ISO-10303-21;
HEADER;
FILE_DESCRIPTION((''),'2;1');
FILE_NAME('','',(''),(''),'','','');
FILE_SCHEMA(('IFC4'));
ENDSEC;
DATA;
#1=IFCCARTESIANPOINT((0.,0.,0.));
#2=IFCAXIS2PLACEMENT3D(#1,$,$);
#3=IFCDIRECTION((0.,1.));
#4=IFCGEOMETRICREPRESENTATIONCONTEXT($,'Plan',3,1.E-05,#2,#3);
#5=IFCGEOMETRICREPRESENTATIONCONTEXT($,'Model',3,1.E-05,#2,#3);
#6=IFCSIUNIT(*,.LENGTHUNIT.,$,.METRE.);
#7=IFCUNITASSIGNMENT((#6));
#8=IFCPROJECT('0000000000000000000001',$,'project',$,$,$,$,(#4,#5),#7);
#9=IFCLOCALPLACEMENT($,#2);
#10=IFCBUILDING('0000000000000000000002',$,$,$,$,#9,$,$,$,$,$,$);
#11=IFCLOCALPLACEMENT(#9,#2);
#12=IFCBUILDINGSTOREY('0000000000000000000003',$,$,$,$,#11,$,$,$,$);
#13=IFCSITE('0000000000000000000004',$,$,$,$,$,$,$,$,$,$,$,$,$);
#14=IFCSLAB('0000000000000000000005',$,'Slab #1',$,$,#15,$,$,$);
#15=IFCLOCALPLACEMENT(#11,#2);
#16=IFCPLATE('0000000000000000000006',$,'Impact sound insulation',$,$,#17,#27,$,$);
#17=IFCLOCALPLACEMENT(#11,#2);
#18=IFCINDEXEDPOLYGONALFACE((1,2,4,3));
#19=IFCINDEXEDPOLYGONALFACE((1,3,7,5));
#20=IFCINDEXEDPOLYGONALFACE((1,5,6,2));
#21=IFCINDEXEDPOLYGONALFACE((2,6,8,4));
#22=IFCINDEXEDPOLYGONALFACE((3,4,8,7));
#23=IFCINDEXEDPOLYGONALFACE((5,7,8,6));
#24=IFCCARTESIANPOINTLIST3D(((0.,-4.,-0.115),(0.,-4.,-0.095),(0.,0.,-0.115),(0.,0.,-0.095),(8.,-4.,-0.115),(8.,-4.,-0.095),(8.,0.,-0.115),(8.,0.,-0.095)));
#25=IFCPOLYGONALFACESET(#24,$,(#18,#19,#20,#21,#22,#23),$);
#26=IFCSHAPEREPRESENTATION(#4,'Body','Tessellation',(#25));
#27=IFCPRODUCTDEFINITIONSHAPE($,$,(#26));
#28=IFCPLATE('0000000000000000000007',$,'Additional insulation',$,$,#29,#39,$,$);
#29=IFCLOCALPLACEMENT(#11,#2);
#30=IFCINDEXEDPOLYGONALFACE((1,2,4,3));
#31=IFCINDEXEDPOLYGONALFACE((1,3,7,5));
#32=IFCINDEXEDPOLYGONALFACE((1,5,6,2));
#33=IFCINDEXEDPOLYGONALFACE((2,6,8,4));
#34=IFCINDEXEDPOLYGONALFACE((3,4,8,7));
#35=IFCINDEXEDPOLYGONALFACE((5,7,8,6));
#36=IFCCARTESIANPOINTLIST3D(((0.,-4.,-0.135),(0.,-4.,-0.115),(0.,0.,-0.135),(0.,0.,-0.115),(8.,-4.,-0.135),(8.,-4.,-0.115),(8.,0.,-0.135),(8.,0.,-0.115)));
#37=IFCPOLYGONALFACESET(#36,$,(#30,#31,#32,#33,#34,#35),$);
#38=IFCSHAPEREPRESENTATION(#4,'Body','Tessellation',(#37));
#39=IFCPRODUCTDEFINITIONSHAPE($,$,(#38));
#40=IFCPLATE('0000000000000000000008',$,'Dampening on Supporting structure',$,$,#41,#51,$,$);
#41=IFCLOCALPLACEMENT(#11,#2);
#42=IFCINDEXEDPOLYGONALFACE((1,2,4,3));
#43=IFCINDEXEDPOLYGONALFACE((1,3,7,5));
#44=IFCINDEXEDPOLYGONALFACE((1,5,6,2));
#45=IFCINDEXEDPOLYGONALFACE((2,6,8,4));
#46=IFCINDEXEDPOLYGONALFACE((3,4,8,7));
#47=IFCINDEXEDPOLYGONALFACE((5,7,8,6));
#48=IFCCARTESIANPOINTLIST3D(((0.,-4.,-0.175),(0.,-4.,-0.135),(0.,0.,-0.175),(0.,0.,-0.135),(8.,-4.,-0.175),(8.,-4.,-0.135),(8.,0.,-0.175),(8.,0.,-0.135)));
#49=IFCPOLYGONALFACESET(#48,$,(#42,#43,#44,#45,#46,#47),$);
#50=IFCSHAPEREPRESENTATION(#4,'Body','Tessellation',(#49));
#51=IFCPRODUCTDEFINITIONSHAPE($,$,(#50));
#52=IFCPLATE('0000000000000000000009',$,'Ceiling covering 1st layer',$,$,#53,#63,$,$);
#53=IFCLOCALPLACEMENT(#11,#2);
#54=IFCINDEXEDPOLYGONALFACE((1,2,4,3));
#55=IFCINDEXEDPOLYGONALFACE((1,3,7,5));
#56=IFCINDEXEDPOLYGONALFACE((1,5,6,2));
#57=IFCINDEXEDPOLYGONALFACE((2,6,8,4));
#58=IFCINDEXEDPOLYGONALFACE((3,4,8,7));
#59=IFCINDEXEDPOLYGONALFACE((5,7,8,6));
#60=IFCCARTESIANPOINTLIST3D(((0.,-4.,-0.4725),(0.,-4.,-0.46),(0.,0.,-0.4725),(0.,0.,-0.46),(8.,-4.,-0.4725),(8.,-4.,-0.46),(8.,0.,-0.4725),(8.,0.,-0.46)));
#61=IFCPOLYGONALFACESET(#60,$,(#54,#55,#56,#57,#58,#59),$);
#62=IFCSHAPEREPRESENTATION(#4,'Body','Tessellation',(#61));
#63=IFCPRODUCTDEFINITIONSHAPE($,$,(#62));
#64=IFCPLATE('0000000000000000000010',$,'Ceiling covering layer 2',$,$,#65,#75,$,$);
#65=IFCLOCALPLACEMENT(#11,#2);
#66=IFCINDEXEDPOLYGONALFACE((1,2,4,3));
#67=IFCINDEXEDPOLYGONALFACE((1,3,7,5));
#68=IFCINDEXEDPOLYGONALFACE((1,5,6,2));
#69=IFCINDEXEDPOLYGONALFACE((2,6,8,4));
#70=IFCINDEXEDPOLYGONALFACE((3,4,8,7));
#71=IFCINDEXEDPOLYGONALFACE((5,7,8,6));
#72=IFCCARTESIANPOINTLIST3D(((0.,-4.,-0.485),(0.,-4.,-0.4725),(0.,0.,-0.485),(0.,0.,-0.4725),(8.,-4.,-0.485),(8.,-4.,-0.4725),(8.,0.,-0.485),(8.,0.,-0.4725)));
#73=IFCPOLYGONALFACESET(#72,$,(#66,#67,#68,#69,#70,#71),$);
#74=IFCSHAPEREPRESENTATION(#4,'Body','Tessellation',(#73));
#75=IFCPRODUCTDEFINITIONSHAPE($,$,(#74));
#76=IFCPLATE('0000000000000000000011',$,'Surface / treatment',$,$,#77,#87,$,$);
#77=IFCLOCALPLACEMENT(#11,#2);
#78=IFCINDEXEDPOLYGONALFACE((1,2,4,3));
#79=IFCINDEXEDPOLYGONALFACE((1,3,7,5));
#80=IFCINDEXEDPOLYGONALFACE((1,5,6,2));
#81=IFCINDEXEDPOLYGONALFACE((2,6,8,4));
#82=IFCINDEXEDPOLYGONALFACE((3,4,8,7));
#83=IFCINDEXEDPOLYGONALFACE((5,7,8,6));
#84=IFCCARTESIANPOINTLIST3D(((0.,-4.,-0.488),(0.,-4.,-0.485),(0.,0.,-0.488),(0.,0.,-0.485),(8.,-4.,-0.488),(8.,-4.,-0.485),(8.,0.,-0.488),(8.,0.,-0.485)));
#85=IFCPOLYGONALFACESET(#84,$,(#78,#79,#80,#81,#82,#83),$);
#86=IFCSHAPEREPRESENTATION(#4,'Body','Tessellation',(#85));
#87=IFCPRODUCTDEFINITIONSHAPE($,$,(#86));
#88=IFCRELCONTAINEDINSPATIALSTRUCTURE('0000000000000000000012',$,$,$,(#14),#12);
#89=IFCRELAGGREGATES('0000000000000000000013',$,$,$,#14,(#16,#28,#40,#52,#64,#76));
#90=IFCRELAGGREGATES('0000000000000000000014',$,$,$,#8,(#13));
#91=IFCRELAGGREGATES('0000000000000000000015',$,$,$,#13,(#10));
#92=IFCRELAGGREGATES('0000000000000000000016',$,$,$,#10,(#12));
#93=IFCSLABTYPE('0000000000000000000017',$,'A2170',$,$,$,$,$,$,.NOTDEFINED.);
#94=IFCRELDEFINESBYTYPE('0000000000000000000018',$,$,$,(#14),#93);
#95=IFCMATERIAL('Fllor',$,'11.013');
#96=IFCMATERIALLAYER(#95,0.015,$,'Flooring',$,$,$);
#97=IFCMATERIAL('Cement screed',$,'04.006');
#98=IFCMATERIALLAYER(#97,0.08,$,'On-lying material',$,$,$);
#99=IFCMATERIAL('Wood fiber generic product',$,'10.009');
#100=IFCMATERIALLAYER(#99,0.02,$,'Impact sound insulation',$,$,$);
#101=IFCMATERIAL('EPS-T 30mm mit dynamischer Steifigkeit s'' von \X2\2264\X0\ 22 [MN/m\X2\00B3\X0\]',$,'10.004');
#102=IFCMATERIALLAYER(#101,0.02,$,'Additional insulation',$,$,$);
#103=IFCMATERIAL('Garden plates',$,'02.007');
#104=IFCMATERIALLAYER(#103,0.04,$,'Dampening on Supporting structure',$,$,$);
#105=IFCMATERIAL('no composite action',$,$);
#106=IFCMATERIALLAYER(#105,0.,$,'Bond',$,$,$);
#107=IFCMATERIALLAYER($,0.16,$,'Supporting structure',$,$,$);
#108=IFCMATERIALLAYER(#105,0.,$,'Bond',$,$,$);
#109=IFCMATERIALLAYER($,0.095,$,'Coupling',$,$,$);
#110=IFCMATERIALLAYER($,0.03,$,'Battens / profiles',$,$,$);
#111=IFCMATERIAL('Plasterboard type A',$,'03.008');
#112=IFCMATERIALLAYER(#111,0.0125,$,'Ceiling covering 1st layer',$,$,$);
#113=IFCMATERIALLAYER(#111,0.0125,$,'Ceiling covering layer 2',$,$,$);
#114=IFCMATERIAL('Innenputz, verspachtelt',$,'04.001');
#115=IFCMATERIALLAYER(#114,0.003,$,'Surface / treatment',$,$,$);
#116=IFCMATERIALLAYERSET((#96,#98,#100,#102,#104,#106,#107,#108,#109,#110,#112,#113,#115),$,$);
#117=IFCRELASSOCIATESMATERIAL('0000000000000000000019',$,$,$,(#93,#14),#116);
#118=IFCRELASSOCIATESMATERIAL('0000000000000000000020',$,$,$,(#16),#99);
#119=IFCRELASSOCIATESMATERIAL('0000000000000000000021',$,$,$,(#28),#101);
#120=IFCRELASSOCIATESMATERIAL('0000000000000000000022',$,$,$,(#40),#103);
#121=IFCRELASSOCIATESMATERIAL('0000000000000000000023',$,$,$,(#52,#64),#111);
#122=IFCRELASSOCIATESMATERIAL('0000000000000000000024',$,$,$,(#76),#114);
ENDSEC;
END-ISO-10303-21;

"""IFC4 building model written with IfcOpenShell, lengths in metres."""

from ifc_helpers import new_model, si_unit, direction, frame, frame_2d, origin, place, context, project, spatial, rectangle, extrude, material, layer, layer_set, type_object, element, aggregate, save


model = new_model("IFC4")

# Units and contexts
plan_context = context("Plan", 3, precision=1e-05, world=origin(), true_north=direction((0.0, 1.0)))
model_context = context("Model", 3, precision=1e-05, world=origin(), true_north=direction((0.0, 1.0)))
ifc_project = project(units=[si_unit("LENGTHUNIT", "METRE")], contexts=[plan_context, model_context])

# Site, building, storey
site = spatial("IfcSite", under=ifc_project)
building_placement = place(None, origin())
building = spatial("IfcBuilding", under=site, at=building_placement)
storey_placement = place(building_placement, origin())
storey = spatial("IfcBuildingStorey", under=building, at=storey_placement)

# Slab, plates
ifc_material_1 = material(Name="Fllor", Category="11.013")
ifc_layer_1 = layer(ifc_material_1, 0.015, Name="Flooring")
ifc_material_2 = material(Name="Cement screed", Category="04.006")
ifc_layer_2 = layer(ifc_material_2, 0.08, Name="On-lying material")
ifc_material_3 = material(Name="Wood fiber generic product", Category="10.009")
ifc_layer_3 = layer(ifc_material_3, 0.02, Name="Impact sound insulation")
ifc_material_4 = material(Name="EPS-T 30mm mit dynamischer Steifigkeit s' von ≤ 22 [MN/m³]", Category="10.004")
ifc_layer_4 = layer(ifc_material_4, 0.02, Name="Additional insulation")
ifc_material_5 = material(Name="Garden plates", Category="02.007")
ifc_layer_5 = layer(ifc_material_5, 0.04, Name="Dampening on Supporting structure")
ifc_material_6 = material(Name="no composite action")
ifc_layer_6 = layer(ifc_material_6, 0.0, Name="Bond")
ifc_layer_7 = layer(None, 0.16, Name="Supporting structure")
ifc_layer_8 = layer(ifc_material_6, 0.0, Name="Bond")
ifc_layer_9 = layer(None, 0.095, Name="Coupling")
ifc_layer_10 = layer(None, 0.03, Name="Battens / profiles")
ifc_material_7 = material(Name="Plasterboard type A", Category="03.008")
ifc_layer_11 = layer(ifc_material_7, 0.0125, Name="Ceiling covering 1st layer")
ifc_layer_12 = layer(ifc_material_7, 0.0125, Name="Ceiling covering layer 2")
ifc_material_8 = material(Name="Innenputz, verspachtelt", Category="04.001")
ifc_layer_13 = layer(ifc_material_8, 0.003, Name="Surface / treatment")
ifc_layer_set = layer_set([ifc_layer_1, ifc_layer_2, ifc_layer_3, ifc_layer_4, ifc_layer_5, ifc_layer_6, ifc_layer_7, ifc_layer_8, ifc_layer_9, ifc_layer_10, ifc_layer_11, ifc_layer_12, ifc_layer_13])
slab_type = type_object("IfcSlabType", Name="A2170", PredefinedType="NOTDEFINED", material=ifc_layer_set)
slab_placement = place(None, frame((0.0, 0.0, 0.0), z_axis=(0.0, 0.0, -1.0), x_axis=(1.0, 0.0, 0.0)))
slab = element("IfcSlab", 1, at=slab_placement, inside=storey, type_object=slab_type, material=ifc_layer_set, Name="Slab #1")
plate_1_placement = place(slab_placement, origin())
plate_1 = element("IfcPlate", 2, at=plate_1_placement, material=ifc_material_3, Name="Impact sound insulation", context=plan_context, shape_type="SweptSolid", body=[
    extrude(rectangle(XDim=8.0, YDim=4.0, at=frame_2d((4.0, 2.0), x_axis=(1.0, 0.0))), frame((0.0, 0.0, 0.095), z_axis=(0.0, 0.0, 1.0), x_axis=(1.0, 0.0, 0.0)), (0.0, 0.0, 1.0), 0.02),
])
plate_2_placement = place(slab_placement, origin())
plate_2 = element("IfcPlate", 3, at=plate_2_placement, material=ifc_material_4, Name="Additional insulation", context=plan_context, shape_type="SweptSolid", body=[
    extrude(rectangle(XDim=8.0, YDim=4.0, at=frame_2d((4.0, 2.0), x_axis=(1.0, 0.0))), frame((0.0, 0.0, 0.115), z_axis=(0.0, 0.0, 1.0), x_axis=(1.0, 0.0, 0.0)), (0.0, 0.0, 1.0), 0.02),
])
plate_3_placement = place(slab_placement, origin())
plate_3 = element("IfcPlate", 4, at=plate_3_placement, material=ifc_material_5, Name="Dampening on Supporting structure", context=plan_context, shape_type="SweptSolid", body=[
    extrude(rectangle(XDim=8.0, YDim=4.0, at=frame_2d((4.0, 2.0), x_axis=(1.0, 0.0))), frame((0.0, 0.0, 0.135), z_axis=(0.0, 0.0, 1.0), x_axis=(1.0, 0.0, 0.0)), (0.0, 0.0, 1.0), 0.04),
])
plate_4_placement = place(slab_placement, origin())
plate_4 = element("IfcPlate", 5, at=plate_4_placement, material=ifc_material_7, Name="Ceiling covering 1st layer", context=plan_context, shape_type="SweptSolid", body=[
    extrude(rectangle(XDim=8.0, YDim=4.0, at=frame_2d((4.0, 2.0), x_axis=(1.0, 0.0))), frame((0.0, 0.0, 0.46), z_axis=(0.0, 0.0, 1.0), x_axis=(1.0, 0.0, 0.0)), (0.0, 0.0, 1.0), 0.0125),
])
plate_5_placement = place(slab_placement, origin())
plate_5 = element("IfcPlate", 6, at=plate_5_placement, material=ifc_material_7, Name="Ceiling covering layer 2", context=plan_context, shape_type="SweptSolid", body=[
    extrude(rectangle(XDim=8.0, YDim=4.0, at=frame_2d((4.0, 2.0), x_axis=(1.0, 0.0))), frame((0.0, 0.0, 0.4725), z_axis=(0.0, 0.0, 1.0), x_axis=(1.0, 0.0, 0.0)), (0.0, 0.0, 1.0), 0.0125),
])
plate_6_placement = place(slab_placement, origin())
plate_6 = element("IfcPlate", 7, at=plate_6_placement, material=ifc_material_8, Name="Surface / treatment", context=plan_context, shape_type="SweptSolid", body=[
    extrude(rectangle(XDim=8.0, YDim=4.0, at=frame_2d((4.0, 2.0), x_axis=(1.0, 0.0))), frame((0.0, 0.0, 0.485), z_axis=(0.0, 0.0, 1.0), x_axis=(1.0, 0.0, 0.0)), (0.0, 0.0, 1.0), 0.003),
])
aggregate(slab, [plate_1, plate_2, plate_3, plate_4, plate_5, plate_6])

save(model, "model.ifc")
